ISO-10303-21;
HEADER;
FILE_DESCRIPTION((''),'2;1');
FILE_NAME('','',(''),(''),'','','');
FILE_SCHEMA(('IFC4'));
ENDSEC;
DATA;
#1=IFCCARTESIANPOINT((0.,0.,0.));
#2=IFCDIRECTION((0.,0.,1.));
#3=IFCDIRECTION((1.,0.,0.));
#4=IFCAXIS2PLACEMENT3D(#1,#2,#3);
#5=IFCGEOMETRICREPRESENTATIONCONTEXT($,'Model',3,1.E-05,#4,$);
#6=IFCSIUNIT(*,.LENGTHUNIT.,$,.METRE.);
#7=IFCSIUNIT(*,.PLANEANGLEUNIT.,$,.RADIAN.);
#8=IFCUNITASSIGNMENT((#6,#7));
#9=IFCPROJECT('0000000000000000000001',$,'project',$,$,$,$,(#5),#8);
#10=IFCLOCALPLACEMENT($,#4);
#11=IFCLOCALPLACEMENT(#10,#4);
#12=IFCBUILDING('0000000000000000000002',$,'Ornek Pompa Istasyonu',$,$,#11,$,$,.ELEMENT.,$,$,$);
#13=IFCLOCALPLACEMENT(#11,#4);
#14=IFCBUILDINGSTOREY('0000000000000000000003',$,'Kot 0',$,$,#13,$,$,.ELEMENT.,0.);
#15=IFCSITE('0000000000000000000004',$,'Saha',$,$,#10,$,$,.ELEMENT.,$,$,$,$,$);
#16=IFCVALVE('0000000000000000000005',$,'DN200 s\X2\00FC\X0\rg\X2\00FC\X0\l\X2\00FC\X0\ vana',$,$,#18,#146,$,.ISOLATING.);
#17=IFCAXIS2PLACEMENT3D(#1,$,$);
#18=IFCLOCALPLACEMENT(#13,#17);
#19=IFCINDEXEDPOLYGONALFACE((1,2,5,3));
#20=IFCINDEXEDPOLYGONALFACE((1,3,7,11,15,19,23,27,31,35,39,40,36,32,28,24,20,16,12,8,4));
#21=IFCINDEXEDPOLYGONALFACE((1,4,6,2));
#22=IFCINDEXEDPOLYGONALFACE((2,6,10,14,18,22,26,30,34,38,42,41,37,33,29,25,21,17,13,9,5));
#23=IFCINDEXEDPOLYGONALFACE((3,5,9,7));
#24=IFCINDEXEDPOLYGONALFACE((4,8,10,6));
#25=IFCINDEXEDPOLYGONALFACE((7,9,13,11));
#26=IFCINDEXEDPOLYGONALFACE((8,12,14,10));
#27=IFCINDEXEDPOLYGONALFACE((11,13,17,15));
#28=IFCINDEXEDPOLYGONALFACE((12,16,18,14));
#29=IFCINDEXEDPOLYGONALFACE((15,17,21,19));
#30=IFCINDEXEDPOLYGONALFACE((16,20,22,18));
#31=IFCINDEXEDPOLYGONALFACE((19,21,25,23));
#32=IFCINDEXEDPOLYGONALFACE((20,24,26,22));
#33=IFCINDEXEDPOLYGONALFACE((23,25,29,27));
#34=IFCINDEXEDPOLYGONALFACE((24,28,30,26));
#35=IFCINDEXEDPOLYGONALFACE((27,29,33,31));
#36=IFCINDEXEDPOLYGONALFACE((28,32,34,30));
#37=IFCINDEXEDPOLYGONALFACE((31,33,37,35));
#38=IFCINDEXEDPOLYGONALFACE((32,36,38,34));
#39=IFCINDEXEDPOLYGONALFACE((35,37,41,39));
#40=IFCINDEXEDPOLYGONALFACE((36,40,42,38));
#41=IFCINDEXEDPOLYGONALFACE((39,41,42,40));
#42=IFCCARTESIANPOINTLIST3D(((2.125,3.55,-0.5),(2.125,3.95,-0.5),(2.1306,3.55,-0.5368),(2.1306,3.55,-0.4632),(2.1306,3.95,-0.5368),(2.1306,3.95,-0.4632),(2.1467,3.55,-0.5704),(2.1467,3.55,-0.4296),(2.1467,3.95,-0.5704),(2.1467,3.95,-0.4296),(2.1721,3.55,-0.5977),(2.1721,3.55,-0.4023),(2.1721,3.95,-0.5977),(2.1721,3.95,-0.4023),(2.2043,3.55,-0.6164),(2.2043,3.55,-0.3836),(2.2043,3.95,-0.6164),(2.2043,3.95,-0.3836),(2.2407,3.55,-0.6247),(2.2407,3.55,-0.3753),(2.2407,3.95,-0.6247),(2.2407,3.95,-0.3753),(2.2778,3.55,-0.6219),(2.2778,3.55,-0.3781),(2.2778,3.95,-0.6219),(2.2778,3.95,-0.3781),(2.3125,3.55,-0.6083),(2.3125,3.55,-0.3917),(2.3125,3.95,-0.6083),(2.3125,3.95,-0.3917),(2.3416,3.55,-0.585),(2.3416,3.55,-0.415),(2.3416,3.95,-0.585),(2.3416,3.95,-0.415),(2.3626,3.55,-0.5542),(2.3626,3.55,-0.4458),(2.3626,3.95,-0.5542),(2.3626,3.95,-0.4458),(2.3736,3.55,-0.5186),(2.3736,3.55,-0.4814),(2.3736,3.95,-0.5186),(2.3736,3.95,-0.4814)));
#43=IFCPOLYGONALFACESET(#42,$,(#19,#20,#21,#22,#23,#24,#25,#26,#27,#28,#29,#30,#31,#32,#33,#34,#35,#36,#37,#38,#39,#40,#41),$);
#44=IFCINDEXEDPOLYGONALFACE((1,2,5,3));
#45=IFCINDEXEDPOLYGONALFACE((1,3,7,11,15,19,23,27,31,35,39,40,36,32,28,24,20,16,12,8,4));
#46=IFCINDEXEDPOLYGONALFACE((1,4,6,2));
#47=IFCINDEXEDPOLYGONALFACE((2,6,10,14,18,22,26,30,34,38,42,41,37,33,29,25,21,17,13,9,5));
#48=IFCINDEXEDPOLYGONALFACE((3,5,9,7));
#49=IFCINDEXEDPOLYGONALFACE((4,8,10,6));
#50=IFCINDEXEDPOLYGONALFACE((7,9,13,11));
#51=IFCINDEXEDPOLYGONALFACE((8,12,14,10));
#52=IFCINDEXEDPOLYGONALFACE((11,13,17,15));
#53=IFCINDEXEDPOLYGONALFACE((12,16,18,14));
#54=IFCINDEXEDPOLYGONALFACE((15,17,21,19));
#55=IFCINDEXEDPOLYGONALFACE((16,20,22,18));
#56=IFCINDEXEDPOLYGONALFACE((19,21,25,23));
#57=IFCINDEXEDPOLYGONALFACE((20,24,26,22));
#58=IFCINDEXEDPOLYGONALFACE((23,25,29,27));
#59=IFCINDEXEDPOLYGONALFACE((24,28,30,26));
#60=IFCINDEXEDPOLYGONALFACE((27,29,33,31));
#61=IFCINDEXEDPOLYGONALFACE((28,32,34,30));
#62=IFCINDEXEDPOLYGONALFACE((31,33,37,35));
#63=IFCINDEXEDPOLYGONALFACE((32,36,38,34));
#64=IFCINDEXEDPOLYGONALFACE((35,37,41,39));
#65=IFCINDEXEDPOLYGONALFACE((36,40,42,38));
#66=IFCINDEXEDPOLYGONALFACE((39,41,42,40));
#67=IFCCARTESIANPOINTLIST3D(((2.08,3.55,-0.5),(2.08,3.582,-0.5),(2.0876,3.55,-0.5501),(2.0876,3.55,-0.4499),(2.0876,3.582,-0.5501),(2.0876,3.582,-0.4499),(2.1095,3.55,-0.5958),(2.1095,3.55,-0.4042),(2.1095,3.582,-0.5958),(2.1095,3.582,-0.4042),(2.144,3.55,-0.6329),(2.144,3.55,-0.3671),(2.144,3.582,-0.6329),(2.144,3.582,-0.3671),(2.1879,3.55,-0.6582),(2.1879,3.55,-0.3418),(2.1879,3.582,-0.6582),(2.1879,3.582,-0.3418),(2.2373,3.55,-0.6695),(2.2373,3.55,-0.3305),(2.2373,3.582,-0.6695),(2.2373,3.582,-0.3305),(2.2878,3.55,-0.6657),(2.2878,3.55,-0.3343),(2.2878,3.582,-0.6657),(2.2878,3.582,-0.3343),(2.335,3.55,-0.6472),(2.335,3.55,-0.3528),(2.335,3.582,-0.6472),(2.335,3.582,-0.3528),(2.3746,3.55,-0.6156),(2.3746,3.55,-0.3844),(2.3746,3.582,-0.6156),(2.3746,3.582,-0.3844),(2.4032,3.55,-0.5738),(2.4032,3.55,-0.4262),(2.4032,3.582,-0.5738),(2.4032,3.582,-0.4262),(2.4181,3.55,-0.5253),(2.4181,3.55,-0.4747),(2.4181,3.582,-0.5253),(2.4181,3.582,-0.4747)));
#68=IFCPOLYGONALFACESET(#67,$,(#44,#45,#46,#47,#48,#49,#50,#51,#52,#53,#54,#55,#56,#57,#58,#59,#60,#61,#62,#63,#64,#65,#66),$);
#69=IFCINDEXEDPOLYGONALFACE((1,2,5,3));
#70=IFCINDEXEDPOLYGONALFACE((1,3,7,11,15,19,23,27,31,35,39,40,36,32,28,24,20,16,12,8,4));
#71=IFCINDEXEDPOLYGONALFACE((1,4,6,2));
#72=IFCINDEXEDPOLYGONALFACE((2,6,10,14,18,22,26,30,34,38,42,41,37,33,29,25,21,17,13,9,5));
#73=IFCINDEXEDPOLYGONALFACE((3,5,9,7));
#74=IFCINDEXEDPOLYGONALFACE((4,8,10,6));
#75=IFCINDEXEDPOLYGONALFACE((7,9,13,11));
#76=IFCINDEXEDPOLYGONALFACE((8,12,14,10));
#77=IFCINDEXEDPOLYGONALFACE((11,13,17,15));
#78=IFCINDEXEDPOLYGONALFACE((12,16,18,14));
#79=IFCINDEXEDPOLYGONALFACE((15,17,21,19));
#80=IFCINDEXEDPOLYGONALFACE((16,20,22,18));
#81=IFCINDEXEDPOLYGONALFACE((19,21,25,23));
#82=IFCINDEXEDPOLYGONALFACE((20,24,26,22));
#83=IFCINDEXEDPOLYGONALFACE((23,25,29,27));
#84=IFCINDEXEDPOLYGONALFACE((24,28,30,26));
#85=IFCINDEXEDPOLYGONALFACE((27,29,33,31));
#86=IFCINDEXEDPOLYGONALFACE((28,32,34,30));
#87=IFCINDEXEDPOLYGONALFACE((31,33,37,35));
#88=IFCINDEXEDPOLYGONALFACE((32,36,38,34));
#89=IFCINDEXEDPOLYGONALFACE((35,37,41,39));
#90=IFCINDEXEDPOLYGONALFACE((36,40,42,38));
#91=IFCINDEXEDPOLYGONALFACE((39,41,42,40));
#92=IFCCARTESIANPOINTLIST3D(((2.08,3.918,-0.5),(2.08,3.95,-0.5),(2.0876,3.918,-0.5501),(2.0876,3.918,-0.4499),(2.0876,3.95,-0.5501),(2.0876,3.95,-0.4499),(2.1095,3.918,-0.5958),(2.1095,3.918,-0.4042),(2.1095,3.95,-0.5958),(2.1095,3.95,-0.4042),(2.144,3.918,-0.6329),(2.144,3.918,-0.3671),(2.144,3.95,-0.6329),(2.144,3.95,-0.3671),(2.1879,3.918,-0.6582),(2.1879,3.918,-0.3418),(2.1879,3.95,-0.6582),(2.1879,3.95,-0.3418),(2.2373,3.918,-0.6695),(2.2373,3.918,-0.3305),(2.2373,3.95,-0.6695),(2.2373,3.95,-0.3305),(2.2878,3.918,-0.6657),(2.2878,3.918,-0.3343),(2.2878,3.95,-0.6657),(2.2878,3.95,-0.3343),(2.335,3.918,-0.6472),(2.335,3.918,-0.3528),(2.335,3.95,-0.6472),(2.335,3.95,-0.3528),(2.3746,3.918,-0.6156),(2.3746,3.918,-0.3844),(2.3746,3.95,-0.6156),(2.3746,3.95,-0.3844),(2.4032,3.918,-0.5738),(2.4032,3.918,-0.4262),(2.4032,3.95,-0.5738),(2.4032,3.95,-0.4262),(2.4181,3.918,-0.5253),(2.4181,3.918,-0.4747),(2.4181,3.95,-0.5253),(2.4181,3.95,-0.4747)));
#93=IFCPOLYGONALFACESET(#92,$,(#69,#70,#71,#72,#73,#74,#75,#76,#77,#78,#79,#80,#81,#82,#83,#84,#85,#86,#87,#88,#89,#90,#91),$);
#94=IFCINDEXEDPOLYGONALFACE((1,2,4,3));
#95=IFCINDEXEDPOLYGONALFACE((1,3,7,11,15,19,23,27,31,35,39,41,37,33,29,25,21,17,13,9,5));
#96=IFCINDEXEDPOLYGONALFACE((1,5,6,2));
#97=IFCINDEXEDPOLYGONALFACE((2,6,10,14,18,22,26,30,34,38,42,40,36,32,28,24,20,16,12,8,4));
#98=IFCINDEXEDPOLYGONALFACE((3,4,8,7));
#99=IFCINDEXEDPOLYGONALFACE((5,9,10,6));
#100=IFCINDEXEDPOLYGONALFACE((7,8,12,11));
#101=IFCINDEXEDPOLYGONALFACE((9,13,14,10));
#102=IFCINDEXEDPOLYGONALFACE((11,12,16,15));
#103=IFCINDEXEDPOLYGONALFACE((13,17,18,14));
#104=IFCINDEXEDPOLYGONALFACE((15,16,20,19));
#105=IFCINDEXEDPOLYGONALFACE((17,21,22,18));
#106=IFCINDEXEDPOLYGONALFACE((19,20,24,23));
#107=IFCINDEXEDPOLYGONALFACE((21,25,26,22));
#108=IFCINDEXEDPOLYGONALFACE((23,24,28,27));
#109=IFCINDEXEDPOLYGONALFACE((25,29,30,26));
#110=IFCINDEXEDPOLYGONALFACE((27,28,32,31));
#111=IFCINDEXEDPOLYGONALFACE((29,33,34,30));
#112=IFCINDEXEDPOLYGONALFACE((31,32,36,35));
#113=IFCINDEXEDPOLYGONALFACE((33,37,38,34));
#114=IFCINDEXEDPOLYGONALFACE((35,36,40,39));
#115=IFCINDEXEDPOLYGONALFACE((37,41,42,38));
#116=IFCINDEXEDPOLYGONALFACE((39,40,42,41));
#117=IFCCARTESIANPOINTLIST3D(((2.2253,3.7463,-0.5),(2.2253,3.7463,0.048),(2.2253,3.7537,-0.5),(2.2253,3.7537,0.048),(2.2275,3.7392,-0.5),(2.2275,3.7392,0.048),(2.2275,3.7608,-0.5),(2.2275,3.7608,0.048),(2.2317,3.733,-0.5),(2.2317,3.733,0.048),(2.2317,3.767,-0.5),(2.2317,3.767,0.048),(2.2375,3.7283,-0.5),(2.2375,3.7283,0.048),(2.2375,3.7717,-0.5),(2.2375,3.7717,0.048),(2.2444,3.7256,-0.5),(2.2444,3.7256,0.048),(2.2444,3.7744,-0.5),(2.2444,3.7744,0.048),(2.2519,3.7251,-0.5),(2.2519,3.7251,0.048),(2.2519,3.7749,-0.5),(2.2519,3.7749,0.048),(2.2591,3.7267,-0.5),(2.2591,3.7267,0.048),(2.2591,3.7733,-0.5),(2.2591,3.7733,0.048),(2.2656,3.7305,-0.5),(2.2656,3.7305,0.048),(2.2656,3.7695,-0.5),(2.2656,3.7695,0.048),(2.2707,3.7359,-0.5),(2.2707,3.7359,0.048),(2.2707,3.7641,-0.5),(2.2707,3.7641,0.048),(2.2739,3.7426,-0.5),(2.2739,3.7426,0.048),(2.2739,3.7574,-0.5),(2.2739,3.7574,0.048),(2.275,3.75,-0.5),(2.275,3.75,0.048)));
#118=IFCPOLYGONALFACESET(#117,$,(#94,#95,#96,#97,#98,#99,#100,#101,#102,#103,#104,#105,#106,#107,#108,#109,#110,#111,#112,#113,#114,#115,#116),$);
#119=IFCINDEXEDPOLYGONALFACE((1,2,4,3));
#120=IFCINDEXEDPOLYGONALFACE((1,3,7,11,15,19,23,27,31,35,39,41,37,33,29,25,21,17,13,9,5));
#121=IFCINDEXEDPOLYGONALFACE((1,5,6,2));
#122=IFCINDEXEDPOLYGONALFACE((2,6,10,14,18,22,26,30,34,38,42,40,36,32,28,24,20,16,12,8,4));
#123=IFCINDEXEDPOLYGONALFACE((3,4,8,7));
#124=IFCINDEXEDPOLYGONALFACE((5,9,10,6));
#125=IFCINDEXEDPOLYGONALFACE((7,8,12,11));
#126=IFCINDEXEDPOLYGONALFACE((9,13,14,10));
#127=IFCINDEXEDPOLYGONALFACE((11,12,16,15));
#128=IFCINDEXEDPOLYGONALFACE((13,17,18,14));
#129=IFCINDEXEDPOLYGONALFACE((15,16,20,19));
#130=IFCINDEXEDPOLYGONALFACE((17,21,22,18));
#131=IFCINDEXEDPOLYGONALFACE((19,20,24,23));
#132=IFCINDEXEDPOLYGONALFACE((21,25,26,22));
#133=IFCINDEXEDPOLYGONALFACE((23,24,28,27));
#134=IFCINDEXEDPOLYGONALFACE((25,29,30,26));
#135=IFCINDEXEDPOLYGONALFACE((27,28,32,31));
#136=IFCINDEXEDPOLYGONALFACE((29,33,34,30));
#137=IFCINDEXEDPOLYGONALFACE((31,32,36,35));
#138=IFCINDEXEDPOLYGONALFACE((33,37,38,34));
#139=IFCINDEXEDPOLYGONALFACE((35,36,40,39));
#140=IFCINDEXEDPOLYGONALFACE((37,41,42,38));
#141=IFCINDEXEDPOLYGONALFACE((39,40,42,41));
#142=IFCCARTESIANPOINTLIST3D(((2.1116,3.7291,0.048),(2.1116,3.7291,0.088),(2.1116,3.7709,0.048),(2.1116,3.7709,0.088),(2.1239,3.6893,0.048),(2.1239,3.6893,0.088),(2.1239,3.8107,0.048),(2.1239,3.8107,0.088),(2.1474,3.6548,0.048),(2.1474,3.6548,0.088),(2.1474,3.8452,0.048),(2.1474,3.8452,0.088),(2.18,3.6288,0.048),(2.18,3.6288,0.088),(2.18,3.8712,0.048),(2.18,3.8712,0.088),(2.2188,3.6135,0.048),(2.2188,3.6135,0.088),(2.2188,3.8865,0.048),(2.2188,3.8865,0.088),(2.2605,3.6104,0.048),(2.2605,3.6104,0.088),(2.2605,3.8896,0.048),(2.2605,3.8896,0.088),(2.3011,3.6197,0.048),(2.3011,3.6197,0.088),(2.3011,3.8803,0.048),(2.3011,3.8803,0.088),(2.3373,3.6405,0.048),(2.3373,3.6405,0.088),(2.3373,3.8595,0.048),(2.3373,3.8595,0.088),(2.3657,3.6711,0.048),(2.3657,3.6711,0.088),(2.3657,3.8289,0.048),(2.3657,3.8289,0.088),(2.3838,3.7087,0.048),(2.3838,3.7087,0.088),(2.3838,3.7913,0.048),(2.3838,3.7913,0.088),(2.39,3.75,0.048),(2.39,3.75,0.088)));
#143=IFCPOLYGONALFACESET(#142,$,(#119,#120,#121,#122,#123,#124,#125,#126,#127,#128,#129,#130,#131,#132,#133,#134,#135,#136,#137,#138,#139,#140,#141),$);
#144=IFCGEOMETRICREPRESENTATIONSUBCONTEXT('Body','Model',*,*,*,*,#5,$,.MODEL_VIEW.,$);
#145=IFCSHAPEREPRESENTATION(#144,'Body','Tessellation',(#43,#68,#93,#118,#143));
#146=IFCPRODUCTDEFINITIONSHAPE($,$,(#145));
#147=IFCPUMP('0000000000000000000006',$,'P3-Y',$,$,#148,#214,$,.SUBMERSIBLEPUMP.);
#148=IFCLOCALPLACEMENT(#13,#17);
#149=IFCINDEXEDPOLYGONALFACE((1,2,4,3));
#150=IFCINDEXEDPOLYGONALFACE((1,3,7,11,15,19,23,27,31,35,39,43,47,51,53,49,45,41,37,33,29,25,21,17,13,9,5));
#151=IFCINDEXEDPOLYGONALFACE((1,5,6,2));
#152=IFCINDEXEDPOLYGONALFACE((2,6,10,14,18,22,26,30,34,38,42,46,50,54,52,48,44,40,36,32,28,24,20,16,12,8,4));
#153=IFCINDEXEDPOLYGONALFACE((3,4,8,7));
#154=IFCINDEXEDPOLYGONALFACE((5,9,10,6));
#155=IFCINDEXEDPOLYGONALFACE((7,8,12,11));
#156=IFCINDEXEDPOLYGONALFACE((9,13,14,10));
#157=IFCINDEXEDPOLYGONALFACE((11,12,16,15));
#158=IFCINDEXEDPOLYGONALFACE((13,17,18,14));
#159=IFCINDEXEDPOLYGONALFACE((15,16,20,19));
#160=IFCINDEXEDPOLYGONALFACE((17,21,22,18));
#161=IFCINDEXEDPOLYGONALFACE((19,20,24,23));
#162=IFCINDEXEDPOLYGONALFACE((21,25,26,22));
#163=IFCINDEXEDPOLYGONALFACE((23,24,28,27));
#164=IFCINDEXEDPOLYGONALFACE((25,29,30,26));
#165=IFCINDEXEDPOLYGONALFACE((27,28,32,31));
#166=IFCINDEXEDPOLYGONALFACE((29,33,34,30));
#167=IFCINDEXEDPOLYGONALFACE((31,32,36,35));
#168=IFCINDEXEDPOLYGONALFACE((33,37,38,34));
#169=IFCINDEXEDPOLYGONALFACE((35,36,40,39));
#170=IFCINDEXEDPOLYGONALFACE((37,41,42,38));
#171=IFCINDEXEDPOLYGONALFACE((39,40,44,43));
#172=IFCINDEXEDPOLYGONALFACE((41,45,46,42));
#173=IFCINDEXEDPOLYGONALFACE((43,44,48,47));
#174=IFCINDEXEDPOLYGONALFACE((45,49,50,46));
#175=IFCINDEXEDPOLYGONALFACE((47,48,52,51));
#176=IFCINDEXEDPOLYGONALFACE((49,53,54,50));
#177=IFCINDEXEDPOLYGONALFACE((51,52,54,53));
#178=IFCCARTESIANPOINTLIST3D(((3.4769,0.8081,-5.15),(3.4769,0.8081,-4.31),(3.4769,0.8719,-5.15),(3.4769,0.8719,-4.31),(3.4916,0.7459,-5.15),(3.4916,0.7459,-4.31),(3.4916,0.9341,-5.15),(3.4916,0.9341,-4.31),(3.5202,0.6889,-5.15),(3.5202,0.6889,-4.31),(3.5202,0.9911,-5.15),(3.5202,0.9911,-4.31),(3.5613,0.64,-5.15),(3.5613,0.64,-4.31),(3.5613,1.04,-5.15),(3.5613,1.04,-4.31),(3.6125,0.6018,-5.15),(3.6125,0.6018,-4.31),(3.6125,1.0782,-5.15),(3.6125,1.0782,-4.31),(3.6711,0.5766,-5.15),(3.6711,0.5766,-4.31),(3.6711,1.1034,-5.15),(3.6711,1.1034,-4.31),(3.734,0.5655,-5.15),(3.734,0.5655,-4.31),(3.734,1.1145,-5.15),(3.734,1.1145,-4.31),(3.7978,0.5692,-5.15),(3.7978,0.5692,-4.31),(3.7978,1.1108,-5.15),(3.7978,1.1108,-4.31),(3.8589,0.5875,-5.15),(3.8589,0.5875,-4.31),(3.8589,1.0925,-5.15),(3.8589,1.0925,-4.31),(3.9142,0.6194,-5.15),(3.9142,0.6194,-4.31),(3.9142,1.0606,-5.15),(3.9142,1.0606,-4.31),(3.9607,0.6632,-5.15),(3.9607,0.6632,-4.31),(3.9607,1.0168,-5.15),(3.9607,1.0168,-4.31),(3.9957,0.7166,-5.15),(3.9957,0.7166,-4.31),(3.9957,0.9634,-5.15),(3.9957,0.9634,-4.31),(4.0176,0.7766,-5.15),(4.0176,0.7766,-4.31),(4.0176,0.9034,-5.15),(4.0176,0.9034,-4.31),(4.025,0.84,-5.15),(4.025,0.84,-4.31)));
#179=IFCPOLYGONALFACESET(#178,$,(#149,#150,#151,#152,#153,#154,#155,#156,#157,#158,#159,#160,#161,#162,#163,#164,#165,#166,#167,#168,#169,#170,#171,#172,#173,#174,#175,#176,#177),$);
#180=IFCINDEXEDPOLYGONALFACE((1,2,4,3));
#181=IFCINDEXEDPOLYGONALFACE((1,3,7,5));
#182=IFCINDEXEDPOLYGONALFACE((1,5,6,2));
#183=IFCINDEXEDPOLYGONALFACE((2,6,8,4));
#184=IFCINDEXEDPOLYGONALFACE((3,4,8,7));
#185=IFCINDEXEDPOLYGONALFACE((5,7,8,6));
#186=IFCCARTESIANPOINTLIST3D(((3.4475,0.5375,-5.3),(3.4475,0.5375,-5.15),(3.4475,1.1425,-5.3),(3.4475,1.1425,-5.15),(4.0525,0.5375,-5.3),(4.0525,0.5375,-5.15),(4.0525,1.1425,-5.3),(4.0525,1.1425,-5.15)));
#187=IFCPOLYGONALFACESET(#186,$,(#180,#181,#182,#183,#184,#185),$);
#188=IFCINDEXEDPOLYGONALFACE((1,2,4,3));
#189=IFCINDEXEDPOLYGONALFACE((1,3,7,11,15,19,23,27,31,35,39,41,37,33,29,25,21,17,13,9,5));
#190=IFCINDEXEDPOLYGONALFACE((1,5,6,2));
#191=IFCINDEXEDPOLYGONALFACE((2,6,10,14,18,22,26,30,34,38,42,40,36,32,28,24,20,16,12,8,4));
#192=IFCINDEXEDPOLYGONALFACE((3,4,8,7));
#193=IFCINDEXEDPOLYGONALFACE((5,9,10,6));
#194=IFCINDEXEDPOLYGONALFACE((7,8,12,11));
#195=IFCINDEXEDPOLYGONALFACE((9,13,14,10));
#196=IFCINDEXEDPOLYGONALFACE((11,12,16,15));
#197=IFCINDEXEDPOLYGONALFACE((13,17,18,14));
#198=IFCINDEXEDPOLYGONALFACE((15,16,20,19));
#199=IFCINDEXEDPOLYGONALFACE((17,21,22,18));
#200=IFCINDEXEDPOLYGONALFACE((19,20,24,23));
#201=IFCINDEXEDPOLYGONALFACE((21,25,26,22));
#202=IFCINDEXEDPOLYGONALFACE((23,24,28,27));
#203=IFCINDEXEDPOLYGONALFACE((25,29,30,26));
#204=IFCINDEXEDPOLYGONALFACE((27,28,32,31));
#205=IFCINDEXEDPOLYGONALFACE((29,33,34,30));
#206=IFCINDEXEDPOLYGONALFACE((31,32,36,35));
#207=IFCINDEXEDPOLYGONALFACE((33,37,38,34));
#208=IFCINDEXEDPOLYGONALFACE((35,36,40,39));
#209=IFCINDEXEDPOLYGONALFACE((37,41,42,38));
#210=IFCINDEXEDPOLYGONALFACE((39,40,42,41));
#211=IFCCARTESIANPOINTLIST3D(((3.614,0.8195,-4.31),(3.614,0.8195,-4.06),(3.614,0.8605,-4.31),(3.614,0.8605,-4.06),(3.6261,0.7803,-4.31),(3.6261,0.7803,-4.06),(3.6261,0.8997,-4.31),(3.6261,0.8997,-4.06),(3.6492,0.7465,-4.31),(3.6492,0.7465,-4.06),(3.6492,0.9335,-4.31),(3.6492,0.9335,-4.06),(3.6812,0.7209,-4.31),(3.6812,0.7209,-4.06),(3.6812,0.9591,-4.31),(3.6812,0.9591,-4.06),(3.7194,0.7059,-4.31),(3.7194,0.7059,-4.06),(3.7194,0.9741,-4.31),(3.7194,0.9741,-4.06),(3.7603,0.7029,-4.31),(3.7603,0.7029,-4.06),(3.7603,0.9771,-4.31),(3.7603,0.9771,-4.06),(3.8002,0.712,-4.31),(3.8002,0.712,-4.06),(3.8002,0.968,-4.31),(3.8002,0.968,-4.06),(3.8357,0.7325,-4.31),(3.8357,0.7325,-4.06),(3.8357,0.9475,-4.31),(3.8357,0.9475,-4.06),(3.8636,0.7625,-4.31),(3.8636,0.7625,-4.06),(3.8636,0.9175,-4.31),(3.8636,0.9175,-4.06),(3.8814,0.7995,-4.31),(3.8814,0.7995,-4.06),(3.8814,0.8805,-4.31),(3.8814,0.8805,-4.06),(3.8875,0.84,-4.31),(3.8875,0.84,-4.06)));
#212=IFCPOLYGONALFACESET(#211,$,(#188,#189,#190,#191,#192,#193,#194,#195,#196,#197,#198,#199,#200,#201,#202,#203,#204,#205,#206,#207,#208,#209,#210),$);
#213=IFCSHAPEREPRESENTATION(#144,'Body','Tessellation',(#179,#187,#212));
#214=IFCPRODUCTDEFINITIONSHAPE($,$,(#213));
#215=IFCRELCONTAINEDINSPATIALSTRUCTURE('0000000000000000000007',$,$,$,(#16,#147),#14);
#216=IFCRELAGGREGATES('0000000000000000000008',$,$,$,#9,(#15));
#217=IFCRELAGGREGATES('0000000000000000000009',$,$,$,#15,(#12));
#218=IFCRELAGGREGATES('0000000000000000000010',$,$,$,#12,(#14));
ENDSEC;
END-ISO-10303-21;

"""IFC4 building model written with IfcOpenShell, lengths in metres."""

from ifc_helpers import new_model, si_unit, frame, origin_with_axes, origin_2d, place, context, subcontext, project, spatial, polyline, circle, outline, extrude, element, save


model = new_model("IFC4")

# Units and contexts
model_context = context("Model", 3, precision=1e-05, world=origin_with_axes())
body_context = subcontext(model_context, "Body", "Model", "MODEL_VIEW")
ifc_project = project(units=[si_unit("LENGTHUNIT", "METRE"), si_unit("PLANEANGLEUNIT", "RADIAN")], contexts=[model_context])

# Site, building, storey
site_placement = place(None, origin_with_axes())
site = spatial("IfcSite", under=ifc_project, at=site_placement, Name="Saha", CompositionType="ELEMENT")
building_placement = place(site_placement, origin_with_axes())
building = spatial("IfcBuilding", under=site, at=building_placement, Name="Ornek Pompa Istasyonu", CompositionType="ELEMENT")
storey_placement = place(building_placement, origin_with_axes())
storey = spatial("IfcBuildingStorey", under=building, at=storey_placement, Name="Kot 0", CompositionType="ELEMENT", Elevation=0.0)

# Valve
valve_1_placement = place(storey_placement, origin_with_axes())
element("IfcValve", 1, at=valve_1_placement, inside=storey, Name="DN200 sürgülü vana", PredefinedType="ISOLATING", context=body_context, shape_type="SweptSolid", body=[
    extrude(circle(Radius=0.125, at=origin_2d()), frame((2.25, 3.55, -0.5), z_axis=(0.0, 1.0, 0.0), x_axis=(-1.0, 0.0, 0.0)), (0.0, 0.0, 1.0), 0.4),
    extrude(circle(Radius=0.17, at=origin_2d()), frame((2.25, 3.55, -0.5), z_axis=(0.0, 1.0, 0.0), x_axis=(-1.0, 0.0, 0.0)), (0.0, 0.0, 1.0), 0.032),
    extrude(circle(Radius=0.17, at=origin_2d()), frame((2.25, 3.918, -0.5), z_axis=(0.0, 1.0, 0.0), x_axis=(-1.0, 0.0, 0.0)), (0.0, 0.0, 1.0), 0.032),
    extrude(circle(Radius=0.025, at=origin_2d()), frame((2.25, 3.75, -0.5), z_axis=(0.0, 0.0, 1.0), x_axis=(1.0, 0.0, 0.0)), (0.0, 0.0, 1.0), 0.548),
    extrude(circle(Radius=0.14, at=origin_2d()), frame((2.25, 3.75, 0.048), z_axis=(0.0, 0.0, 1.0), x_axis=(1.0, 0.0, 0.0)), (0.0, 0.0, 1.0), 0.04),
])

# Pump
pump_1_placement = place(storey_placement, origin_with_axes())
element("IfcPump", 2, at=pump_1_placement, inside=storey, Name="P3-Y", PredefinedType="SUBMERSIBLEPUMP", context=body_context, shape_type="SweptSolid", body=[
    extrude(circle(Radius=0.275, at=origin_2d()), frame((3.75, 0.84, -5.15), z_axis=(0.0, 0.0, 1.0), x_axis=(1.0, 0.0, 0.0)), (0.0, 0.0, 1.0), 0.84),
    extrude(outline(polyline([(0.0, 0.0), (0.605, 0.0), (0.605, 0.605), (0.0, 0.605), (0.0, 0.0)])), frame((4.0525, 0.5375, -5.3), z_axis=(0.0, 0.0, 1.0), x_axis=(0.0, 1.0, 0.0)), (0.0, 0.0, 1.0), 0.15),
    extrude(circle(Radius=0.1375, at=origin_2d()), frame((3.75, 0.84, -4.31), z_axis=(0.0, 0.0, 1.0), x_axis=(1.0, 0.0, 0.0)), (0.0, 0.0, 1.0), 0.25),
])

save(model, "model.ifc")
